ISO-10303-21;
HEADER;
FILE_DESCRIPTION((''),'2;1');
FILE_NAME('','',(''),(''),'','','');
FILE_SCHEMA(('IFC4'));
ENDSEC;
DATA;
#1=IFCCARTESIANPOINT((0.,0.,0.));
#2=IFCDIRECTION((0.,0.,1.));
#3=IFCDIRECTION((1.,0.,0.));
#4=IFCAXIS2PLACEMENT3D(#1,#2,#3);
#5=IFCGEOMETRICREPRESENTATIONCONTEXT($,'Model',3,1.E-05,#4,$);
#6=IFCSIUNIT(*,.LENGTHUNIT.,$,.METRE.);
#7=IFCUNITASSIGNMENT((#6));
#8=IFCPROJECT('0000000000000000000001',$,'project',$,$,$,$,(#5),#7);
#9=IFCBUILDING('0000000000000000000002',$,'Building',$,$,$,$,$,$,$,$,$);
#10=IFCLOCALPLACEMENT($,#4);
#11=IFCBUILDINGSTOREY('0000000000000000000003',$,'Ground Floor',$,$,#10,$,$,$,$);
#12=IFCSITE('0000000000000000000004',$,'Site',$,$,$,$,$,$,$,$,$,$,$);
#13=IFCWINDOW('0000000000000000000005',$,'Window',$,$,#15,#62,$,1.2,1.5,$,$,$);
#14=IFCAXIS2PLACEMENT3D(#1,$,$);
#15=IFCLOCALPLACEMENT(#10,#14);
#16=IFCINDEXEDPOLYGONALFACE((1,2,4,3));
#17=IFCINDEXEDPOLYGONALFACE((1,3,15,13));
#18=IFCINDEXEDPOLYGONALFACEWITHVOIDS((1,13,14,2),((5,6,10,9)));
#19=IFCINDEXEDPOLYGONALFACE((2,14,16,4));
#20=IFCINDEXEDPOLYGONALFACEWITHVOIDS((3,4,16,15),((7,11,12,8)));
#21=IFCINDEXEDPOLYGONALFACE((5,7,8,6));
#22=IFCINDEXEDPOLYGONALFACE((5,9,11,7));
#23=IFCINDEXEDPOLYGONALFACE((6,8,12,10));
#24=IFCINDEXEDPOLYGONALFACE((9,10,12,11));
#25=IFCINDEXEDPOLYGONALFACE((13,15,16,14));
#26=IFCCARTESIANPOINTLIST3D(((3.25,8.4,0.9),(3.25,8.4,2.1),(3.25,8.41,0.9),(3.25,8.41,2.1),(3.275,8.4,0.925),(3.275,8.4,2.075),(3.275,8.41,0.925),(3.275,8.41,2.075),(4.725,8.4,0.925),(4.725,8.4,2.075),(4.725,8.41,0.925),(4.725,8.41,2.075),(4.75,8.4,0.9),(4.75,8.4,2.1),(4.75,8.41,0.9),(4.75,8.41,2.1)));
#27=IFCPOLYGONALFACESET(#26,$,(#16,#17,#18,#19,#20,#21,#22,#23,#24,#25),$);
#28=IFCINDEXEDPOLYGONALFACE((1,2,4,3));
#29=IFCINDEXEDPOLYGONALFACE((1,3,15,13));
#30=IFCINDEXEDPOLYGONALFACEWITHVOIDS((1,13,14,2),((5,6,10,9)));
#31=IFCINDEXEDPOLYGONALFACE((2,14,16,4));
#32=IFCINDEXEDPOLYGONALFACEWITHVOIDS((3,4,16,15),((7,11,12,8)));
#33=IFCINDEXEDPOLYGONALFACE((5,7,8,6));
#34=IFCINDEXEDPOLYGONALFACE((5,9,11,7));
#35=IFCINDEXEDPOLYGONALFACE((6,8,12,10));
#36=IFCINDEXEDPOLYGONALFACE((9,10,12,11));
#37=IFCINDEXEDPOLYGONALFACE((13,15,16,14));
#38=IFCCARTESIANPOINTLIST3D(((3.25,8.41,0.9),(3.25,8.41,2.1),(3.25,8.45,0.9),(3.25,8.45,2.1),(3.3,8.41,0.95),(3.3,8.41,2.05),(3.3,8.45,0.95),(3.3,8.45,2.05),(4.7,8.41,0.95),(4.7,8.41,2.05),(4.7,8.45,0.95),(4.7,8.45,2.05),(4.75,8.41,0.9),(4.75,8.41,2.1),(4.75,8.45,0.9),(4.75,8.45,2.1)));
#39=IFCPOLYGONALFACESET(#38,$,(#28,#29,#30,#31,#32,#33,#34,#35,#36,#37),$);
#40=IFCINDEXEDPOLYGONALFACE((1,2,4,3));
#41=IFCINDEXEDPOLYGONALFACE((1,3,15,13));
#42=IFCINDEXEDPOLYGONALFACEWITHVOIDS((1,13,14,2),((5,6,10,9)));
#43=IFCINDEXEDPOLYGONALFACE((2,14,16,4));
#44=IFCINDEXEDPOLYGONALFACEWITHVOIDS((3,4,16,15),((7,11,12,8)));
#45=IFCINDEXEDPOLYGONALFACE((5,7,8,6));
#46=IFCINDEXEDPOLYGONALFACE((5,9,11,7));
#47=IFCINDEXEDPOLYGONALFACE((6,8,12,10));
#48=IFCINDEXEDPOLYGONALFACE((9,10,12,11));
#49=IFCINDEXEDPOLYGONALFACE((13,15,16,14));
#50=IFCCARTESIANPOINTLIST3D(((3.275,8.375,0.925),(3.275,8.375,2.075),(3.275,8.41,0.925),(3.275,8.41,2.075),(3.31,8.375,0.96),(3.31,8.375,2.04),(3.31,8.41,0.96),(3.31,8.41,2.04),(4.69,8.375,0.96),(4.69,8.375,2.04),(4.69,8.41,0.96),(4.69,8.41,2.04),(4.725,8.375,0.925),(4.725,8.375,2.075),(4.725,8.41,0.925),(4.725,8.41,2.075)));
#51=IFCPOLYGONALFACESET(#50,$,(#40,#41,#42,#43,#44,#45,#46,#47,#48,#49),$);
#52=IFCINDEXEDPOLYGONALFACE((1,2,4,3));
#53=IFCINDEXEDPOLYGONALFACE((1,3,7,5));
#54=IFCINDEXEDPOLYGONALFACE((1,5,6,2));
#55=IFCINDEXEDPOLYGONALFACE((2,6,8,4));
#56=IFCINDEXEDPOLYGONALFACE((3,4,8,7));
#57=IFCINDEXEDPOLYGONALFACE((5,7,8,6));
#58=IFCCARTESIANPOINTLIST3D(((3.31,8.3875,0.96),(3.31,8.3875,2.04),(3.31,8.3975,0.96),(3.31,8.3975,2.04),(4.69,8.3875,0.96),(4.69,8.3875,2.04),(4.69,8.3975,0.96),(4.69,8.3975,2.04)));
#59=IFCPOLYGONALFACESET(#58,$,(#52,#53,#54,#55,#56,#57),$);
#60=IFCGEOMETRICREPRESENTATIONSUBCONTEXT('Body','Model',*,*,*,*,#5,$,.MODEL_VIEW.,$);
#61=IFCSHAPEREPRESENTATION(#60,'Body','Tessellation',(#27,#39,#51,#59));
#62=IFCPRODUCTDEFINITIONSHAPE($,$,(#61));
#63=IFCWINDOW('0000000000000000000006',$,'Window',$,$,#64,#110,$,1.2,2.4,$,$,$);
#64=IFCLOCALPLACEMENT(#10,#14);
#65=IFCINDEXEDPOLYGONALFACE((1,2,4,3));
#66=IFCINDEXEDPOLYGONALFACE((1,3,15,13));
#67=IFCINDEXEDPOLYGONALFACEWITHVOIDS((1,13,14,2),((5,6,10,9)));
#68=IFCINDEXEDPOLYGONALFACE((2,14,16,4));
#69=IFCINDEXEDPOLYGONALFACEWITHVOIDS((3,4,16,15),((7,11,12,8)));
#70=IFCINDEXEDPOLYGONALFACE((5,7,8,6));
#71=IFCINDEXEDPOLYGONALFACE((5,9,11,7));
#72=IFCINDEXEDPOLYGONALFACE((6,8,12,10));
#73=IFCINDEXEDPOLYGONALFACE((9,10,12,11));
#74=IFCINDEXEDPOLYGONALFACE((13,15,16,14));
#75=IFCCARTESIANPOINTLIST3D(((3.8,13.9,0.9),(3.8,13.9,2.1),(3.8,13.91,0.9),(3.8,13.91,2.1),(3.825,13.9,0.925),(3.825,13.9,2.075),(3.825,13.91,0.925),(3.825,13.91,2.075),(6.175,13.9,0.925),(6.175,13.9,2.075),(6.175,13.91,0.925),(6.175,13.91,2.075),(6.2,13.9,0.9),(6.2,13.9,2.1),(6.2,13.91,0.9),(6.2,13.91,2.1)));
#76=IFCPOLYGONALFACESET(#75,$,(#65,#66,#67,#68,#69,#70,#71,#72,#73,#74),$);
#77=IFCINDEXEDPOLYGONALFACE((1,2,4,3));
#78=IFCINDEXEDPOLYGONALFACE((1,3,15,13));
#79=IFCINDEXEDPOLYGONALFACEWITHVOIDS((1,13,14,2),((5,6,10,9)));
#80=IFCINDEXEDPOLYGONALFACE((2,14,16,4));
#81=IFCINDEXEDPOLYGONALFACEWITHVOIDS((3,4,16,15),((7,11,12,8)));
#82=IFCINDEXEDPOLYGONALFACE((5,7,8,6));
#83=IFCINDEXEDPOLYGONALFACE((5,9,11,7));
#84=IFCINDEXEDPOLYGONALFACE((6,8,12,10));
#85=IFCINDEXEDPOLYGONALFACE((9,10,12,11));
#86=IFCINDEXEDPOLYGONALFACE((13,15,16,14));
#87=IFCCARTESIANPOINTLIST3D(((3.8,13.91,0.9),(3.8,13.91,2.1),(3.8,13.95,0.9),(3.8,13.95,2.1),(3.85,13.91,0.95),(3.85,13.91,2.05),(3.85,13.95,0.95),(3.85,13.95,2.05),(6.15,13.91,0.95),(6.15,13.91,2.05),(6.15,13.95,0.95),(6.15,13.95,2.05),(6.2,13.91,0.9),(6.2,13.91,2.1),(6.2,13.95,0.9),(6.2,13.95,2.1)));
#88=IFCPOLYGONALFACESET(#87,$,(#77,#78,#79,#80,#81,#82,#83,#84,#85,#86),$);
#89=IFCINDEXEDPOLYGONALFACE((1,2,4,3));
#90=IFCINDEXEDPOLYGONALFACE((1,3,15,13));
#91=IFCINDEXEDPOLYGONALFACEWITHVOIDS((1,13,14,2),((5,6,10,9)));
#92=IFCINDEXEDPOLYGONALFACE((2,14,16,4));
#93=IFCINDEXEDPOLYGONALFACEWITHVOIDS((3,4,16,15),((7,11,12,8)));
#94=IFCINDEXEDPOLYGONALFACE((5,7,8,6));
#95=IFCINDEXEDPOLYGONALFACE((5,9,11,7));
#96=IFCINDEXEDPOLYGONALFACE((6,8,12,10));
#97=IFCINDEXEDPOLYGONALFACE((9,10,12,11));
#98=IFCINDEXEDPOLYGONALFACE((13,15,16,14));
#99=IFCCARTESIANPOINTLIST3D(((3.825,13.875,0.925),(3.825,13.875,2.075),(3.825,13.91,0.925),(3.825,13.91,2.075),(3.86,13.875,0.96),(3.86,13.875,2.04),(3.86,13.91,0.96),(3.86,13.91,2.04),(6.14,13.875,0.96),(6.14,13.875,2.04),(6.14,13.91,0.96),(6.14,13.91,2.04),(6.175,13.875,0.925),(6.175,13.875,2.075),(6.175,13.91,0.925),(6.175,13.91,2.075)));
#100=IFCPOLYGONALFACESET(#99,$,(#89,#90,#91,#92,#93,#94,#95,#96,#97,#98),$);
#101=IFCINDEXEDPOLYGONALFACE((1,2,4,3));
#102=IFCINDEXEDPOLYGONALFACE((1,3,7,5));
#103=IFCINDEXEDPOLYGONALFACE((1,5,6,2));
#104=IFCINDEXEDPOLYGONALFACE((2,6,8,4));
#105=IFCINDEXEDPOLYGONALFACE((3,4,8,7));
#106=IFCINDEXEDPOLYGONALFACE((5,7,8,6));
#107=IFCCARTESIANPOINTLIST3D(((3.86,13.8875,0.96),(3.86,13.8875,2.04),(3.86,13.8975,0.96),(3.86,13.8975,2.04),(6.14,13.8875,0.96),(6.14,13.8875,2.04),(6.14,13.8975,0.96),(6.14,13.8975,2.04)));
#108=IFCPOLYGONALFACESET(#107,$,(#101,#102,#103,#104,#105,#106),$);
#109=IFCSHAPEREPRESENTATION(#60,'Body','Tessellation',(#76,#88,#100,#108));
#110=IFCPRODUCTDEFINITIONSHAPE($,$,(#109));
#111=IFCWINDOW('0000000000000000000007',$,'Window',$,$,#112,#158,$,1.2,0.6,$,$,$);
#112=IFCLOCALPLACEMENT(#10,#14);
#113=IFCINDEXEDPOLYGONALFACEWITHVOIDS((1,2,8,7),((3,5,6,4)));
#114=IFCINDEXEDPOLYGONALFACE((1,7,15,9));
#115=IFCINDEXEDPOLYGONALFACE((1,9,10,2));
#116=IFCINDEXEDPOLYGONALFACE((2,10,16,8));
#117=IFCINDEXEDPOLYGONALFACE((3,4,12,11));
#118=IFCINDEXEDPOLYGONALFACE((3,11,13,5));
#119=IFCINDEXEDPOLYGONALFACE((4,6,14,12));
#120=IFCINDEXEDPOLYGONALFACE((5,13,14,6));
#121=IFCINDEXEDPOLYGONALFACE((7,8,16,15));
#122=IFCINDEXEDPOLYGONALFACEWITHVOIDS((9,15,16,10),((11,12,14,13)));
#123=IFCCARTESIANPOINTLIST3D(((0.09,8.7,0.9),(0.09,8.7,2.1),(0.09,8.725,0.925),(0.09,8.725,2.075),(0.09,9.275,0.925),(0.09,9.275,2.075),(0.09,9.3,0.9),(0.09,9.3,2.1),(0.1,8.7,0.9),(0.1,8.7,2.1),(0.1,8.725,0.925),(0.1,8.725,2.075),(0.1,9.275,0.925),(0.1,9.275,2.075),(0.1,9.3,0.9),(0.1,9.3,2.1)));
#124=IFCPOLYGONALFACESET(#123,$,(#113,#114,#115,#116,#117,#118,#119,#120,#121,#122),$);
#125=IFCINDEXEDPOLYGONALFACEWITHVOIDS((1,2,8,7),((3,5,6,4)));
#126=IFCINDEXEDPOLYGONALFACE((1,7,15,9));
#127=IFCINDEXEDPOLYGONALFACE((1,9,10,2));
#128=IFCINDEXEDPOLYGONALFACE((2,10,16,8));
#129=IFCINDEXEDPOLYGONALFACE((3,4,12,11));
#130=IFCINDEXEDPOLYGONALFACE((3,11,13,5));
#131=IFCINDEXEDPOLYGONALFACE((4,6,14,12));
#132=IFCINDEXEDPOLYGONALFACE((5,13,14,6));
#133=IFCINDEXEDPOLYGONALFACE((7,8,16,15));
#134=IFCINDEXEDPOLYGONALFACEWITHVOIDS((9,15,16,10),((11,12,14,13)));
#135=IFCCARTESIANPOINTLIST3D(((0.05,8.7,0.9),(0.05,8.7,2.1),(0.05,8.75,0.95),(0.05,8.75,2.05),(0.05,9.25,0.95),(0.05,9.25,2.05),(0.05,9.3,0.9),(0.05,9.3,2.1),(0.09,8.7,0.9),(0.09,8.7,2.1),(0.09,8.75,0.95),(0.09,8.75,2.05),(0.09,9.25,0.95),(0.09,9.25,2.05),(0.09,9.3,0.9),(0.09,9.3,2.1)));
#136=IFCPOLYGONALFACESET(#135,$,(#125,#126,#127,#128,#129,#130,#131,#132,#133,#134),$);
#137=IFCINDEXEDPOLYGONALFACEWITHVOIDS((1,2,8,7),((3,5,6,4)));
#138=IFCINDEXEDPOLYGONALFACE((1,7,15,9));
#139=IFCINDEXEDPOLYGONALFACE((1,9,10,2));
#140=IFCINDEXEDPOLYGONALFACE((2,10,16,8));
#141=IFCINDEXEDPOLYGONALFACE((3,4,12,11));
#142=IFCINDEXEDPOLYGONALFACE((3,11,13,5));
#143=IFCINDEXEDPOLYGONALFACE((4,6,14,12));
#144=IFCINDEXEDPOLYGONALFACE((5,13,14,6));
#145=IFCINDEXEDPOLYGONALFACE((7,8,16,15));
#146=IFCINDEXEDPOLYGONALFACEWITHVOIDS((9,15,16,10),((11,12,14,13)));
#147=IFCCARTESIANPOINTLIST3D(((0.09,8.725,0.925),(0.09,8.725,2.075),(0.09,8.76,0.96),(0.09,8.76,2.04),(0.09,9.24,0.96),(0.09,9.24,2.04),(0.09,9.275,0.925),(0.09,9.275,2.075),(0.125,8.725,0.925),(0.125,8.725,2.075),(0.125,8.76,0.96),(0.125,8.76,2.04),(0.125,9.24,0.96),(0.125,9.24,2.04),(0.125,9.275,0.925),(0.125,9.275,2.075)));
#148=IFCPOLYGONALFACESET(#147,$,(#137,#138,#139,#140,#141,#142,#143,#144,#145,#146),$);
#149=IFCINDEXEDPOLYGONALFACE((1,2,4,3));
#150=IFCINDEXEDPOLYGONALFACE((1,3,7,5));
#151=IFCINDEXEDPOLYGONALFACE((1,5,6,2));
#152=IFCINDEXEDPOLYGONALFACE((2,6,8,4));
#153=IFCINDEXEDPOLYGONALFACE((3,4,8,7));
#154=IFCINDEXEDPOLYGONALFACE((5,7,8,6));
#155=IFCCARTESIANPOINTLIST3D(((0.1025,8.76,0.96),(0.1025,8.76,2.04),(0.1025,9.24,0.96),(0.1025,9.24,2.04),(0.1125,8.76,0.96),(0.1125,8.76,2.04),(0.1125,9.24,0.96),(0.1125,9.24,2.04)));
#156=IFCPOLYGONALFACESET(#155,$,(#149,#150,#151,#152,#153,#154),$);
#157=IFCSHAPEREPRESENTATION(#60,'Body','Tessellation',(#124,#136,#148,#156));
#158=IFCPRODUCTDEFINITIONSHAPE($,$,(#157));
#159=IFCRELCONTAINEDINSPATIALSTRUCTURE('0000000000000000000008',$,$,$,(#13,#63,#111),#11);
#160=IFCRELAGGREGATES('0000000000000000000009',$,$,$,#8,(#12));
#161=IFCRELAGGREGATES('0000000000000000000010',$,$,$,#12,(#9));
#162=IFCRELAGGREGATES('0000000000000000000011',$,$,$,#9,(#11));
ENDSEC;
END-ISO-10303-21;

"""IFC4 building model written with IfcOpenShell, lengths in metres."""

from ifc_helpers import new_model, si_unit, frame, origin_with_axes, place, context, subcontext, project, spatial, line, indexed_curve, outline, extrude, element, save


model = new_model("IFC4")

# Units and contexts
model_context = context("Model", 3, precision=1e-05, world=origin_with_axes())
body_context = subcontext(model_context, "Body", "Model", "MODEL_VIEW")
ifc_project = project(units=[si_unit("LENGTHUNIT", "METRE")], contexts=[model_context])

# Site, building, storey
site = spatial("IfcSite", under=ifc_project, Name="Site")
building = spatial("IfcBuilding", under=site, Name="Building")
storey_placement = place(None, origin_with_axes())
storey = spatial("IfcBuildingStorey", under=building, at=storey_placement, Name="Ground Floor")

# Windows
window_1_placement = place(storey_placement, frame((4.75, 8.5, 0.9), z_axis=(0.0, 0.0, 1.0), x_axis=(-1.0, 0.0, 0.0)))
element("IfcWindow", 1, at=window_1_placement, inside=storey, Name="Window", OverallHeight=1.2, OverallWidth=1.5, context=body_context, shape_type="SweptSolid", body=[
    extrude(outline(indexed_curve([(0.0, 0.0), (1.5, 0.0), (1.5, 1.2), (0.0, 1.2)], segments=[line(1, 2, 3, 4, 1)]), holes=[indexed_curve([(0.025, 0.025), (1.475, 0.025), (1.475, 1.175), (0.025, 1.175)], segments=[line(1, 2, 3, 4, 1)])]), frame((0.0, 0.09, 0.0), z_axis=(0.0, -1.0, 0.0), x_axis=(1.0, 0.0, 0.0)), (0.0, 0.0, -1.0), 0.01),
    extrude(outline(indexed_curve([(0.0, 0.0), (1.5, 0.0), (1.5, 1.2), (0.0, 1.2)], segments=[line(1, 2, 3, 4, 1)]), holes=[indexed_curve([(0.05, 0.05), (1.45, 0.05), (1.45, 1.15), (0.05, 1.15)], segments=[line(1, 2, 3, 4, 1)])]), frame((0.0, 0.05, 0.0), z_axis=(0.0, -1.0, 0.0), x_axis=(1.0, 0.0, 0.0)), (0.0, 0.0, -1.0), 0.04),
    extrude(outline(indexed_curve([(0.0, 0.0), (1.45, 0.0), (1.45, 1.15), (0.0, 1.15)], segments=[line(1, 2, 3, 4, 1)]), holes=[indexed_curve([(0.035, 0.035), (1.415, 0.035), (1.415, 1.115), (0.035, 1.115)], segments=[line(1, 2, 3, 4, 1)])]), frame((0.025, 0.09, 0.025), z_axis=(0.0, -1.0, 0.0), x_axis=(1.0, 0.0, 0.0)), (0.0, 0.0, -1.0), 0.035),
    extrude(outline(indexed_curve([(0.035, 0.035), (1.415, 0.035), (1.415, 1.115), (0.035, 1.115)], segments=[line(1, 2, 3, 4, 1)])), frame((0.025, 0.1025, 0.025), z_axis=(0.0, -1.0, 0.0), x_axis=(1.0, 0.0, 0.0)), (0.0, 0.0, -1.0), 0.01),
])
window_2_placement = place(storey_placement, frame((6.2, 14.0, 0.9), z_axis=(0.0, 0.0, 1.0), x_axis=(-1.0, 0.0, 0.0)))
element("IfcWindow", 2, at=window_2_placement, inside=storey, Name="Window", OverallHeight=1.2, OverallWidth=2.4, context=body_context, shape_type="SweptSolid", body=[
    extrude(outline(indexed_curve([(0.0, 0.0), (2.4, 0.0), (2.4, 1.2), (0.0, 1.2)], segments=[line(1, 2, 3, 4, 1)]), holes=[indexed_curve([(0.025, 0.025), (2.375, 0.025), (2.375, 1.175), (0.025, 1.175)], segments=[line(1, 2, 3, 4, 1)])]), frame((0.0, 0.09, 0.0), z_axis=(0.0, -1.0, 0.0), x_axis=(1.0, 0.0, 0.0)), (0.0, 0.0, -1.0), 0.01),
    extrude(outline(indexed_curve([(0.0, 0.0), (2.4, 0.0), (2.4, 1.2), (0.0, 1.2)], segments=[line(1, 2, 3, 4, 1)]), holes=[indexed_curve([(0.05, 0.05), (2.35, 0.05), (2.35, 1.15), (0.05, 1.15)], segments=[line(1, 2, 3, 4, 1)])]), frame((0.0, 0.05, 0.0), z_axis=(0.0, -1.0, 0.0), x_axis=(1.0, 0.0, 0.0)), (0.0, 0.0, -1.0), 0.04),
    extrude(outline(indexed_curve([(0.0, 0.0), (2.35, 0.0), (2.35, 1.15), (0.0, 1.15)], segments=[line(1, 2, 3, 4, 1)]), holes=[indexed_curve([(0.035, 0.035), (2.315, 0.035), (2.315, 1.115), (0.035, 1.115)], segments=[line(1, 2, 3, 4, 1)])]), frame((0.025, 0.09, 0.025), z_axis=(0.0, -1.0, 0.0), x_axis=(1.0, 0.0, 0.0)), (0.0, 0.0, -1.0), 0.035),
    extrude(outline(indexed_curve([(0.035, 0.035), (2.315, 0.035), (2.315, 1.115), (0.035, 1.115)], segments=[line(1, 2, 3, 4, 1)])), frame((0.025, 0.1025, 0.025), z_axis=(0.0, -1.0, 0.0), x_axis=(1.0, 0.0, 0.0)), (0.0, 0.0, -1.0), 0.01),
])
window_3_placement = place(storey_placement, frame((0.0, 9.3, 0.9), z_axis=(0.0, 0.0, 1.0), x_axis=(0.0, -1.0, 0.0)))
element("IfcWindow", 3, at=window_3_placement, inside=storey, Name="Window", OverallHeight=1.2, OverallWidth=0.6, context=body_context, shape_type="SweptSolid", body=[
    extrude(outline(indexed_curve([(0.0, 0.0), (0.6, 0.0), (0.6, 1.2), (0.0, 1.2)], segments=[line(1, 2, 3, 4, 1)]), holes=[indexed_curve([(0.025, 0.025), (0.575, 0.025), (0.575, 1.175), (0.025, 1.175)], segments=[line(1, 2, 3, 4, 1)])]), frame((0.0, 0.09, 0.0), z_axis=(0.0, -1.0, 0.0), x_axis=(1.0, 0.0, 0.0)), (0.0, 0.0, -1.0), 0.01),
    extrude(outline(indexed_curve([(0.0, 0.0), (0.6, 0.0), (0.6, 1.2), (0.0, 1.2)], segments=[line(1, 2, 3, 4, 1)]), holes=[indexed_curve([(0.05, 0.05), (0.55, 0.05), (0.55, 1.15), (0.05, 1.15)], segments=[line(1, 2, 3, 4, 1)])]), frame((0.0, 0.05, 0.0), z_axis=(0.0, -1.0, 0.0), x_axis=(1.0, 0.0, 0.0)), (0.0, 0.0, -1.0), 0.04),
    extrude(outline(indexed_curve([(0.0, 0.0), (0.55, 0.0), (0.55, 1.15), (0.0, 1.15)], segments=[line(1, 2, 3, 4, 1)]), holes=[indexed_curve([(0.035, 0.035), (0.515, 0.035), (0.515, 1.115), (0.035, 1.115)], segments=[line(1, 2, 3, 4, 1)])]), frame((0.025, 0.09, 0.025), z_axis=(0.0, -1.0, 0.0), x_axis=(1.0, 0.0, 0.0)), (0.0, 0.0, -1.0), 0.035),
    extrude(outline(indexed_curve([(0.035, 0.035), (0.515, 0.035), (0.515, 1.115), (0.035, 1.115)], segments=[line(1, 2, 3, 4, 1)])), frame((0.025, 0.1025, 0.025), z_axis=(0.0, -1.0, 0.0), x_axis=(1.0, 0.0, 0.0)), (0.0, 0.0, -1.0), 0.01),
])

save(model, "model.ifc")
